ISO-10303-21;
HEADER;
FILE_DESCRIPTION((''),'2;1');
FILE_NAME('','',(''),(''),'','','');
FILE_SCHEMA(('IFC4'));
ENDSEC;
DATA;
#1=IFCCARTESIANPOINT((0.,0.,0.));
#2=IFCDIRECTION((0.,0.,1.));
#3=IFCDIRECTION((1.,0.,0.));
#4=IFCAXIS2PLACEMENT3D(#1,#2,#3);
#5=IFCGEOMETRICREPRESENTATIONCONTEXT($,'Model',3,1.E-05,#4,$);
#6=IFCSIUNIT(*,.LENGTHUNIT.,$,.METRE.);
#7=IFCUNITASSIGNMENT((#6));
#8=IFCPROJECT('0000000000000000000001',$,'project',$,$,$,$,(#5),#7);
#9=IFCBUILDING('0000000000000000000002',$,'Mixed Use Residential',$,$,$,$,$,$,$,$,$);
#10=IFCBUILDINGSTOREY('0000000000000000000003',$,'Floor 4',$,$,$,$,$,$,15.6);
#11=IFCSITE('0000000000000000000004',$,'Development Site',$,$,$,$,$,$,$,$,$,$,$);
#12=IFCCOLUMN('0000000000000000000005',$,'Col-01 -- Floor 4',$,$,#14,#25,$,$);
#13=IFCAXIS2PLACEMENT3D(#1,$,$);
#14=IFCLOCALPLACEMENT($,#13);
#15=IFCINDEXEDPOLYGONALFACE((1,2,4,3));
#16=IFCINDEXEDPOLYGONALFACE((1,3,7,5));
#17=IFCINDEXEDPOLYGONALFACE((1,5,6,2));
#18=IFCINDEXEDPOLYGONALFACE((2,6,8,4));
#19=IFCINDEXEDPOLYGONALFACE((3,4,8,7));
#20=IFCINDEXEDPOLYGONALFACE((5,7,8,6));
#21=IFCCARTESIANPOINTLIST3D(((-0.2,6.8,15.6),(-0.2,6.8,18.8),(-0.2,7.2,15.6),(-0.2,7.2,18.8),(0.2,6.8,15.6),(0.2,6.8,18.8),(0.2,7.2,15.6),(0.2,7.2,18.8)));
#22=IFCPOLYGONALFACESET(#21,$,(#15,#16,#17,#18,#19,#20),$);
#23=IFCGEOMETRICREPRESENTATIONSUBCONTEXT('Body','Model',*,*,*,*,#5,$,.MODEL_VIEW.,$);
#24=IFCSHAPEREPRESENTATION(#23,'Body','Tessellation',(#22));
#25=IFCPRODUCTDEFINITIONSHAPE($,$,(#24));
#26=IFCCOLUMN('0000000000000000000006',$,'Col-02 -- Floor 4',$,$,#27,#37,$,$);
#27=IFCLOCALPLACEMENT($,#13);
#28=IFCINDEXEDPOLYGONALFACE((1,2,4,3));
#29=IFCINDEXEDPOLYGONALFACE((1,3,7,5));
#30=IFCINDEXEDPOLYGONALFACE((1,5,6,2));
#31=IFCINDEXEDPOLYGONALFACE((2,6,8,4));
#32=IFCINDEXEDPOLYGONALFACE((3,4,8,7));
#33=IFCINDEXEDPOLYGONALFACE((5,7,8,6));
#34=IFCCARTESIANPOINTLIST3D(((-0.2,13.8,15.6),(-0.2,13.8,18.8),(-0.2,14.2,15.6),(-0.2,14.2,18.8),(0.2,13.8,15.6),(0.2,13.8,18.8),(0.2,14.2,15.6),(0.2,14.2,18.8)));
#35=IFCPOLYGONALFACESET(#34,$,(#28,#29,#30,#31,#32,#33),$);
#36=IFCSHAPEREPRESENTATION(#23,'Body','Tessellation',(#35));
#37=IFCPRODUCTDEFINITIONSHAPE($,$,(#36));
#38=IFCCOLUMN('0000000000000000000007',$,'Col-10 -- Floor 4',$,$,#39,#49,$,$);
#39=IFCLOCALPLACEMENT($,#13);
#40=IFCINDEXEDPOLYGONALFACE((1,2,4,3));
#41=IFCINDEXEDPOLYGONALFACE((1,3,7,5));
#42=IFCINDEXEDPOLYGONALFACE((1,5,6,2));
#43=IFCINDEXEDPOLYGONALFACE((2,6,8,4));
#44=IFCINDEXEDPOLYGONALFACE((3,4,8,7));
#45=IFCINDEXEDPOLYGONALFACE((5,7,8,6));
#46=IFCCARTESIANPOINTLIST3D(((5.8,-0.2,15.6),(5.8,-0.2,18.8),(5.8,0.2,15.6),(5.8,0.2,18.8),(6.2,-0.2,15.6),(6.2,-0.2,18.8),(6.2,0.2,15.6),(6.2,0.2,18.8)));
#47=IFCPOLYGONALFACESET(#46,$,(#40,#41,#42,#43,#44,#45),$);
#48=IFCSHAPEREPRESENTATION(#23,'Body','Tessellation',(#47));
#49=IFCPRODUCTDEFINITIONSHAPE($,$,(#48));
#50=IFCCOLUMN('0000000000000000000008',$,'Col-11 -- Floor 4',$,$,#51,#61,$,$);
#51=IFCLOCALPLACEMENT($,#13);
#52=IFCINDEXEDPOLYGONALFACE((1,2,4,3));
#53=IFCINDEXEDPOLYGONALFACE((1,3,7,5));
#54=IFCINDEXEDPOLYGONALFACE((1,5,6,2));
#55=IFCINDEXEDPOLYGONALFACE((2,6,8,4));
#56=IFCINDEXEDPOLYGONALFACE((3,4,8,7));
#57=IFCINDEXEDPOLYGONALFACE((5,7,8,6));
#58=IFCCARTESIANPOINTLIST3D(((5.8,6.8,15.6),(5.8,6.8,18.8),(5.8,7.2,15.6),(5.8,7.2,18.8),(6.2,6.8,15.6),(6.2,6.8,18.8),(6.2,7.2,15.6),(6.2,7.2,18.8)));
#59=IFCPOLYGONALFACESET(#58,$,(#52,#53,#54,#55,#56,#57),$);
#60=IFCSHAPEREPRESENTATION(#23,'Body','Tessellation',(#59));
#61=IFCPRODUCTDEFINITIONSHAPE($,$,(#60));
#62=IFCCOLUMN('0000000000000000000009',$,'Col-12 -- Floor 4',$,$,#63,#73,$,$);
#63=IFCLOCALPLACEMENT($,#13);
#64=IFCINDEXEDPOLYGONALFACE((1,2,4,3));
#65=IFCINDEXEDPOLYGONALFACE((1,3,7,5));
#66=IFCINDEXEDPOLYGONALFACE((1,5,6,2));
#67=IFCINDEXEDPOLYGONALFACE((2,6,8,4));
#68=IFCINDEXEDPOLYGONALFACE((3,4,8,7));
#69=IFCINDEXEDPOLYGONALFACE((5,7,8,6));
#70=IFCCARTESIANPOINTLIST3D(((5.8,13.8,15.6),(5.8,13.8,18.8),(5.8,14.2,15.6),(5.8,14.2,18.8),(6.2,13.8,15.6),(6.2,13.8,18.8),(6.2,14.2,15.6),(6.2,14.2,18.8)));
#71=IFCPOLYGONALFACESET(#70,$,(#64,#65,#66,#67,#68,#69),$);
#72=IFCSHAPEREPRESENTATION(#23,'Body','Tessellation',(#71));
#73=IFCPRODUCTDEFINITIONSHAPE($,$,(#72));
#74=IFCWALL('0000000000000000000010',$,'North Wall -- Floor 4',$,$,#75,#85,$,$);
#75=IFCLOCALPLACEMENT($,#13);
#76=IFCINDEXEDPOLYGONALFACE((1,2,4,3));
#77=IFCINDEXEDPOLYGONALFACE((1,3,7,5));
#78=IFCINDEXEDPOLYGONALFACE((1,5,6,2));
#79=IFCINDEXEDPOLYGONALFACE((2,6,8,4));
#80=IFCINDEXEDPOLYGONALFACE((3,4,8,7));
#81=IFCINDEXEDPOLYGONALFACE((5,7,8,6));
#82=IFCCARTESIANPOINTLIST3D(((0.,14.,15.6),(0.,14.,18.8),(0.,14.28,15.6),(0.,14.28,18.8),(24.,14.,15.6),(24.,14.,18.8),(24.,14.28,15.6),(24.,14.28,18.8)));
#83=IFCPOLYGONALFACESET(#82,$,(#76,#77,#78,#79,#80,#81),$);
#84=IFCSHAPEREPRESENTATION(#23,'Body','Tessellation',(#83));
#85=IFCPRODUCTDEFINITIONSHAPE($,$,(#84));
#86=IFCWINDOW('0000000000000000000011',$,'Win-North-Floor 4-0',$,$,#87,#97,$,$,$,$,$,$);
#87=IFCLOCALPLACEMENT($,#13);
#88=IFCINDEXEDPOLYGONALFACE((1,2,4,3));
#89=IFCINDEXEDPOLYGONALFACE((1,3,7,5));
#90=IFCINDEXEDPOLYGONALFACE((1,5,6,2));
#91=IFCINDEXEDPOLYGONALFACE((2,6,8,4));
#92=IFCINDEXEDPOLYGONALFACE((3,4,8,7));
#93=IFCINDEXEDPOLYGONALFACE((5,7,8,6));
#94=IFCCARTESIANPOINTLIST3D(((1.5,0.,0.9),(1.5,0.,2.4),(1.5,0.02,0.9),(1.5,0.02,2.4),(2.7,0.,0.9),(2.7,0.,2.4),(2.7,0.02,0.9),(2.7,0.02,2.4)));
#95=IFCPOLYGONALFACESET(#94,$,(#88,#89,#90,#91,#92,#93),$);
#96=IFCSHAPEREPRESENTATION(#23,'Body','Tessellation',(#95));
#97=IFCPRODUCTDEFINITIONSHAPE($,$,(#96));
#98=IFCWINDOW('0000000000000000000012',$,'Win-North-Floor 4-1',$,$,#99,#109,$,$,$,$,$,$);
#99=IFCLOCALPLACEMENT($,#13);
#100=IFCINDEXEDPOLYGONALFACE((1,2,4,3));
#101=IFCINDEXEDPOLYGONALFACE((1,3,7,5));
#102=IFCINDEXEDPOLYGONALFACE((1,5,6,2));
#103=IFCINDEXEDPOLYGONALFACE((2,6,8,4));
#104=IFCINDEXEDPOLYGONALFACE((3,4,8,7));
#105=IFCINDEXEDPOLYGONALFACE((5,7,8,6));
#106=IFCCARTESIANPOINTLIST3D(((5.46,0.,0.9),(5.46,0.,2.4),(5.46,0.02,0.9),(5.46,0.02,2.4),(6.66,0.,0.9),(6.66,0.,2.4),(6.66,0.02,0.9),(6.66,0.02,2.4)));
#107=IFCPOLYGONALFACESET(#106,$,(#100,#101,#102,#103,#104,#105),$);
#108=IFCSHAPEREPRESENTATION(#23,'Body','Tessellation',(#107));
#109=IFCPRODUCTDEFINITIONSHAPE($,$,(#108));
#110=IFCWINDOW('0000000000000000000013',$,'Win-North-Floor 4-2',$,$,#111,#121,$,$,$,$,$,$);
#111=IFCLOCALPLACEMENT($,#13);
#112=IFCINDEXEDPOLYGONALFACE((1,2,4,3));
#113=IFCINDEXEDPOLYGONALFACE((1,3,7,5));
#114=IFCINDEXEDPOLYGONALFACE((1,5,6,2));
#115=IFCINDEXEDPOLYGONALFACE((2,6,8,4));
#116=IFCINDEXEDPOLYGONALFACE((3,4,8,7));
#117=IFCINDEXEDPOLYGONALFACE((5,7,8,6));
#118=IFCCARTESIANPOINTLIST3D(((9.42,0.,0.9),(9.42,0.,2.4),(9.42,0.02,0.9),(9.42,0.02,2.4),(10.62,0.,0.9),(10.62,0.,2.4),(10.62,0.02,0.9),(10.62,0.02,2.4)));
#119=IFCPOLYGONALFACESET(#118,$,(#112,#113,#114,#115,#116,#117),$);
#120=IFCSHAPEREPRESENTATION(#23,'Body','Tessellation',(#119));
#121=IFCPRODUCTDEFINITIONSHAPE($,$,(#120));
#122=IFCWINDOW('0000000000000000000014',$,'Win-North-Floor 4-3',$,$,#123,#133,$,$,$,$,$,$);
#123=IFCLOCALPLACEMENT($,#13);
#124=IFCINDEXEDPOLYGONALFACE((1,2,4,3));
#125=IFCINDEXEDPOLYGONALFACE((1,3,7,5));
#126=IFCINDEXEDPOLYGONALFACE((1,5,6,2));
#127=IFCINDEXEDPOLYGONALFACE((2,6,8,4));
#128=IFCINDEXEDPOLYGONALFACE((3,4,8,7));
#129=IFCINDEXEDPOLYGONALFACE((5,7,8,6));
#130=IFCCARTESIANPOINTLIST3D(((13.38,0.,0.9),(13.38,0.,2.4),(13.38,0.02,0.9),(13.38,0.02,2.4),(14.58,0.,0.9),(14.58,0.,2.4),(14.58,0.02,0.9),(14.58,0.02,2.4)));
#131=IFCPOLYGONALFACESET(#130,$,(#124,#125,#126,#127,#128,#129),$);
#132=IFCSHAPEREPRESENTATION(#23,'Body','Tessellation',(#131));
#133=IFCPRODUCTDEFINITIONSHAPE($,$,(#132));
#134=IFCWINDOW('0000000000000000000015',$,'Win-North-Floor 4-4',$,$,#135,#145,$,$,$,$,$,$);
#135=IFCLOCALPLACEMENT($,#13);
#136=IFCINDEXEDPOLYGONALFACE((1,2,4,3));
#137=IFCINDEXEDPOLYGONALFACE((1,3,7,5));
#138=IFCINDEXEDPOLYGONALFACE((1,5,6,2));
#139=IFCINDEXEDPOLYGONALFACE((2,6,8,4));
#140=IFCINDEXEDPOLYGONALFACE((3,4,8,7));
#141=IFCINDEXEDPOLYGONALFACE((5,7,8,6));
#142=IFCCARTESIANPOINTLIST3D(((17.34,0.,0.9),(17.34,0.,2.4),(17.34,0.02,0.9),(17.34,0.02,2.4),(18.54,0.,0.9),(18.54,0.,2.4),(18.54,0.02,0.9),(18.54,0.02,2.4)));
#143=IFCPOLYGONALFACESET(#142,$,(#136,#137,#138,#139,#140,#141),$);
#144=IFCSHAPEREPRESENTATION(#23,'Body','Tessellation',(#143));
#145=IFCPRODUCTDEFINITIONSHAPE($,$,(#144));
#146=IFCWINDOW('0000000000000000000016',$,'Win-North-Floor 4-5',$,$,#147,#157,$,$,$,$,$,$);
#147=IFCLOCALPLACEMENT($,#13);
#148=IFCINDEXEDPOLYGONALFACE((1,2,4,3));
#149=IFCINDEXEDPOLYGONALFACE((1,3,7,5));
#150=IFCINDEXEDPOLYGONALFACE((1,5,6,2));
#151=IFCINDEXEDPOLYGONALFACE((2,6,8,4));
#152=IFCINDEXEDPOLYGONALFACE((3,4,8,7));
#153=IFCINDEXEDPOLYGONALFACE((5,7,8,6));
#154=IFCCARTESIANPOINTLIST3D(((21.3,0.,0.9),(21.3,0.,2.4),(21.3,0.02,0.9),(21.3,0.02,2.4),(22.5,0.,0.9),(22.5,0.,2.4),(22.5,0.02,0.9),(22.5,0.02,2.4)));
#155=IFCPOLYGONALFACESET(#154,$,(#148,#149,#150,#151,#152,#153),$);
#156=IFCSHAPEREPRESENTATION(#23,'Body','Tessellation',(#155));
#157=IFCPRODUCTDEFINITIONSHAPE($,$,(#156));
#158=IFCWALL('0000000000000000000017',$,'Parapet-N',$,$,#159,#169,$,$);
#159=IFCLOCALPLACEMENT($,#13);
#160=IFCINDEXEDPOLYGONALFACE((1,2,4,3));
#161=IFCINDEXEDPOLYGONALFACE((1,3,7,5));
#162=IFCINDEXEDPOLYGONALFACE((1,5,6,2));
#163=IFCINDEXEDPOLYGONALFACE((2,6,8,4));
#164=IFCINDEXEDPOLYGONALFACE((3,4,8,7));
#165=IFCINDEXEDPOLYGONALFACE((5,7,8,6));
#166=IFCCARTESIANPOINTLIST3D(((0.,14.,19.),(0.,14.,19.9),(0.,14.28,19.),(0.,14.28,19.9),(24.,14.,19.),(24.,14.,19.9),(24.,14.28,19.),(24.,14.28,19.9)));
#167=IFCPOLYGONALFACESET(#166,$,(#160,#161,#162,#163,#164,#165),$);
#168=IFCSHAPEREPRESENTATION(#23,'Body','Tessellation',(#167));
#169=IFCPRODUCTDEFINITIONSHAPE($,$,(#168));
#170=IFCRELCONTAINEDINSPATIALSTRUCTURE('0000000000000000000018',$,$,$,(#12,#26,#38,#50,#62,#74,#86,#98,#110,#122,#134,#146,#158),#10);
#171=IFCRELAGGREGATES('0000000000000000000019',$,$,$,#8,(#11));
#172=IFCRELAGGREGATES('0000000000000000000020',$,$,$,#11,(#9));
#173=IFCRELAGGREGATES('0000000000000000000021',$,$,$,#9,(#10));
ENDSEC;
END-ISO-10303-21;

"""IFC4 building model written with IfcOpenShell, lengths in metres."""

from ifc_helpers import new_model, si_unit, frame, origin_with_axes, place, context, subcontext, project, spatial, indexed_curve, rectangle, outline, extrude, element, fill, save


model = new_model("IFC4")

# Units and contexts
model_context = context("Model", 3, precision=1e-05, world=origin_with_axes())
body_context = subcontext(model_context, "Body", "Model", "MODEL_VIEW")
ifc_project = project(units=[si_unit("LENGTHUNIT", "METRE")], contexts=[model_context])

# Site, building, storey
site = spatial("IfcSite", under=ifc_project, Name="Development Site")
building = spatial("IfcBuilding", under=site, Name="Mixed Use Residential")
storey = spatial("IfcBuildingStorey", under=building, Name="Floor 4", Elevation=15.6)

# Columns
for number, where, z_axis, x_axis, name in (
    (1, (0.0, 7.0, 15.6), (0.0, 0.0, 1.0), (1.0, 0.0, 0.0), "Col-01 -- Floor 4"),
    (2, (0.0, 14.0, 15.6), (0.0, 0.0, 1.0), (1.0, 0.0, 0.0), "Col-02 -- Floor 4"),
    (3, (6.0, 0.0, 15.6), (0.0, 0.0, 1.0), (1.0, 0.0, 0.0), "Col-10 -- Floor 4"),
    (4, (6.0, 7.0, 15.6), (0.0, 0.0, 1.0), (1.0, 0.0, 0.0), "Col-11 -- Floor 4"),
    (5, (6.0, 14.0, 15.6), (0.0, 0.0, 1.0), (1.0, 0.0, 0.0), "Col-12 -- Floor 4"),
):
    element("IfcColumn", number, at=place(None, frame(where, z_axis=z_axis, x_axis=x_axis)), inside=storey, Name=name, context=body_context, shape_type="SweptSolid", body=[
        extrude(rectangle(XDim=0.4, YDim=0.4), origin_with_axes(), (0.0, 0.0, 1.0), 3.2),
    ])

# Wall, openings, windows
wall_1_placement = place(None, frame((0.0, 14.0, 15.6), z_axis=(0.0, 0.0, 1.0), x_axis=(1.0, 0.0, 0.0)))
wall_1 = element("IfcWall", 6, at=wall_1_placement, inside=storey, Name="North Wall -- Floor 4", context=body_context, shape_type="SweptSolid", body=[
    extrude(outline(indexed_curve([(0.0, 0.0), (0.0, 0.28), (24.0, 0.28), (24.0, 0.0), (0.0, 0.0)], self_intersect=False)), origin_with_axes(), (0.0, 0.0, 1.0), 3.2),
])
opening_1_placement = place(wall_1_placement, frame((1.5, -14.0, -14.7), z_axis=(0.0, 0.0, 1.0), x_axis=(1.0, 0.0, 0.0)))
opening_1 = element("IfcOpeningElement", 7, at=opening_1_placement, cuts=wall_1, context=body_context, shape_type="SweptSolid", body=[
    extrude(outline(indexed_curve([(0.0, 0.0), (0.0, 0.28), (1.2, 0.28), (1.2, 0.0), (0.0, 0.0)], self_intersect=False)), origin_with_axes(), (0.0, 0.0, 1.0), 1.5),
])
opening_2_placement = place(wall_1_placement, frame((5.46, -14.0, -14.7), z_axis=(0.0, 0.0, 1.0), x_axis=(1.0, 0.0, 0.0)))
opening_2 = element("IfcOpeningElement", 8, at=opening_2_placement, cuts=wall_1, context=body_context, shape_type="SweptSolid", body=[
    extrude(outline(indexed_curve([(0.0, 0.0), (0.0, 0.28), (1.2, 0.28), (1.2, 0.0), (0.0, 0.0)], self_intersect=False)), origin_with_axes(), (0.0, 0.0, 1.0), 1.5),
])
opening_3_placement = place(wall_1_placement, frame((9.42, -14.0, -14.7), z_axis=(0.0, 0.0, 1.0), x_axis=(1.0, 0.0, 0.0)))
opening_3 = element("IfcOpeningElement", 9, at=opening_3_placement, cuts=wall_1, context=body_context, shape_type="SweptSolid", body=[
    extrude(outline(indexed_curve([(0.0, 0.0), (0.0, 0.28), (1.2, 0.28), (1.2, 0.0), (0.0, 0.0)], self_intersect=False)), origin_with_axes(), (0.0, 0.0, 1.0), 1.5),
])
opening_4_placement = place(wall_1_placement, frame((13.38, -14.0, -14.7), z_axis=(0.0, 0.0, 1.0), x_axis=(1.0, 0.0, 0.0)))
opening_4 = element("IfcOpeningElement", 10, at=opening_4_placement, cuts=wall_1, context=body_context, shape_type="SweptSolid", body=[
    extrude(outline(indexed_curve([(0.0, 0.0), (0.0, 0.28), (1.2, 0.28), (1.2, 0.0), (0.0, 0.0)], self_intersect=False)), origin_with_axes(), (0.0, 0.0, 1.0), 1.5),
])
opening_5_placement = place(wall_1_placement, frame((17.34, -14.0, -14.7), z_axis=(0.0, 0.0, 1.0), x_axis=(1.0, 0.0, 0.0)))
opening_5 = element("IfcOpeningElement", 11, at=opening_5_placement, cuts=wall_1, context=body_context, shape_type="SweptSolid", body=[
    extrude(outline(indexed_curve([(0.0, 0.0), (0.0, 0.28), (1.2, 0.28), (1.2, 0.0), (0.0, 0.0)], self_intersect=False)), origin_with_axes(), (0.0, 0.0, 1.0), 1.5),
])
opening_6_placement = place(wall_1_placement, frame((21.3, -14.0, -14.7), z_axis=(0.0, 0.0, 1.0), x_axis=(1.0, 0.0, 0.0)))
opening_6 = element("IfcOpeningElement", 12, at=opening_6_placement, cuts=wall_1, context=body_context, shape_type="SweptSolid", body=[
    extrude(outline(indexed_curve([(0.0, 0.0), (0.0, 0.28), (1.2, 0.28), (1.2, 0.0), (0.0, 0.0)], self_intersect=False)), origin_with_axes(), (0.0, 0.0, 1.0), 1.5),
])
window_1_placement = place(None, frame((1.5, 0.0, 0.9), z_axis=(0.0, 0.0, 1.0), x_axis=(1.0, 0.0, 0.0)))
window_1 = element("IfcWindow", 13, at=window_1_placement, inside=storey, Name="Win-North-Floor 4-0", context=body_context, shape_type="SweptSolid", body=[
    extrude(outline(indexed_curve([(0.0, 0.0), (0.0, 0.02), (1.2, 0.02), (1.2, 0.0), (0.0, 0.0)], self_intersect=False)), origin_with_axes(), (0.0, 0.0, 1.0), 1.5),
])
fill(opening_1, window_1)
window_2_placement = place(None, frame((5.46, 0.0, 0.9), z_axis=(0.0, 0.0, 1.0), x_axis=(1.0, 0.0, 0.0)))
window_2 = element("IfcWindow", 14, at=window_2_placement, inside=storey, Name="Win-North-Floor 4-1", context=body_context, shape_type="SweptSolid", body=[
    extrude(outline(indexed_curve([(0.0, 0.0), (0.0, 0.02), (1.2, 0.02), (1.2, 0.0), (0.0, 0.0)], self_intersect=False)), origin_with_axes(), (0.0, 0.0, 1.0), 1.5),
])
fill(opening_2, window_2)
window_3_placement = place(None, frame((9.42, 0.0, 0.9), z_axis=(0.0, 0.0, 1.0), x_axis=(1.0, 0.0, 0.0)))
window_3 = element("IfcWindow", 15, at=window_3_placement, inside=storey, Name="Win-North-Floor 4-2", context=body_context, shape_type="SweptSolid", body=[
    extrude(outline(indexed_curve([(0.0, 0.0), (0.0, 0.02), (1.2, 0.02), (1.2, 0.0), (0.0, 0.0)], self_intersect=False)), origin_with_axes(), (0.0, 0.0, 1.0), 1.5),
])
fill(opening_3, window_3)
window_4_placement = place(None, frame((13.38, 0.0, 0.9), z_axis=(0.0, 0.0, 1.0), x_axis=(1.0, 0.0, 0.0)))
window_4 = element("IfcWindow", 16, at=window_4_placement, inside=storey, Name="Win-North-Floor 4-3", context=body_context, shape_type="SweptSolid", body=[
    extrude(outline(indexed_curve([(0.0, 0.0), (0.0, 0.02), (1.2, 0.02), (1.2, 0.0), (0.0, 0.0)], self_intersect=False)), origin_with_axes(), (0.0, 0.0, 1.0), 1.5),
])
fill(opening_4, window_4)
window_5_placement = place(None, frame((17.34, 0.0, 0.9), z_axis=(0.0, 0.0, 1.0), x_axis=(1.0, 0.0, 0.0)))
window_5 = element("IfcWindow", 17, at=window_5_placement, inside=storey, Name="Win-North-Floor 4-4", context=body_context, shape_type="SweptSolid", body=[
    extrude(outline(indexed_curve([(0.0, 0.0), (0.0, 0.02), (1.2, 0.02), (1.2, 0.0), (0.0, 0.0)], self_intersect=False)), origin_with_axes(), (0.0, 0.0, 1.0), 1.5),
])
fill(opening_5, window_5)
window_6_placement = place(None, frame((21.3, 0.0, 0.9), z_axis=(0.0, 0.0, 1.0), x_axis=(1.0, 0.0, 0.0)))
window_6 = element("IfcWindow", 18, at=window_6_placement, inside=storey, Name="Win-North-Floor 4-5", context=body_context, shape_type="SweptSolid", body=[
    extrude(outline(indexed_curve([(0.0, 0.0), (0.0, 0.02), (1.2, 0.02), (1.2, 0.0), (0.0, 0.0)], self_intersect=False)), origin_with_axes(), (0.0, 0.0, 1.0), 1.5),
])
fill(opening_6, window_6)

# Wall
wall_2_placement = place(None, frame((0.0, 14.0, 19.0), z_axis=(0.0, 0.0, 1.0), x_axis=(1.0, 0.0, 0.0)))
element("IfcWall", 19, at=wall_2_placement, inside=storey, Name="Parapet-N", context=body_context, shape_type="SweptSolid", body=[
    extrude(outline(indexed_curve([(0.0, 0.0), (0.0, 0.28), (24.0, 0.28), (24.0, 0.0), (0.0, 0.0)], self_intersect=False)), origin_with_axes(), (0.0, 0.0, 1.0), 0.9),
])

save(model, "model.ifc")
